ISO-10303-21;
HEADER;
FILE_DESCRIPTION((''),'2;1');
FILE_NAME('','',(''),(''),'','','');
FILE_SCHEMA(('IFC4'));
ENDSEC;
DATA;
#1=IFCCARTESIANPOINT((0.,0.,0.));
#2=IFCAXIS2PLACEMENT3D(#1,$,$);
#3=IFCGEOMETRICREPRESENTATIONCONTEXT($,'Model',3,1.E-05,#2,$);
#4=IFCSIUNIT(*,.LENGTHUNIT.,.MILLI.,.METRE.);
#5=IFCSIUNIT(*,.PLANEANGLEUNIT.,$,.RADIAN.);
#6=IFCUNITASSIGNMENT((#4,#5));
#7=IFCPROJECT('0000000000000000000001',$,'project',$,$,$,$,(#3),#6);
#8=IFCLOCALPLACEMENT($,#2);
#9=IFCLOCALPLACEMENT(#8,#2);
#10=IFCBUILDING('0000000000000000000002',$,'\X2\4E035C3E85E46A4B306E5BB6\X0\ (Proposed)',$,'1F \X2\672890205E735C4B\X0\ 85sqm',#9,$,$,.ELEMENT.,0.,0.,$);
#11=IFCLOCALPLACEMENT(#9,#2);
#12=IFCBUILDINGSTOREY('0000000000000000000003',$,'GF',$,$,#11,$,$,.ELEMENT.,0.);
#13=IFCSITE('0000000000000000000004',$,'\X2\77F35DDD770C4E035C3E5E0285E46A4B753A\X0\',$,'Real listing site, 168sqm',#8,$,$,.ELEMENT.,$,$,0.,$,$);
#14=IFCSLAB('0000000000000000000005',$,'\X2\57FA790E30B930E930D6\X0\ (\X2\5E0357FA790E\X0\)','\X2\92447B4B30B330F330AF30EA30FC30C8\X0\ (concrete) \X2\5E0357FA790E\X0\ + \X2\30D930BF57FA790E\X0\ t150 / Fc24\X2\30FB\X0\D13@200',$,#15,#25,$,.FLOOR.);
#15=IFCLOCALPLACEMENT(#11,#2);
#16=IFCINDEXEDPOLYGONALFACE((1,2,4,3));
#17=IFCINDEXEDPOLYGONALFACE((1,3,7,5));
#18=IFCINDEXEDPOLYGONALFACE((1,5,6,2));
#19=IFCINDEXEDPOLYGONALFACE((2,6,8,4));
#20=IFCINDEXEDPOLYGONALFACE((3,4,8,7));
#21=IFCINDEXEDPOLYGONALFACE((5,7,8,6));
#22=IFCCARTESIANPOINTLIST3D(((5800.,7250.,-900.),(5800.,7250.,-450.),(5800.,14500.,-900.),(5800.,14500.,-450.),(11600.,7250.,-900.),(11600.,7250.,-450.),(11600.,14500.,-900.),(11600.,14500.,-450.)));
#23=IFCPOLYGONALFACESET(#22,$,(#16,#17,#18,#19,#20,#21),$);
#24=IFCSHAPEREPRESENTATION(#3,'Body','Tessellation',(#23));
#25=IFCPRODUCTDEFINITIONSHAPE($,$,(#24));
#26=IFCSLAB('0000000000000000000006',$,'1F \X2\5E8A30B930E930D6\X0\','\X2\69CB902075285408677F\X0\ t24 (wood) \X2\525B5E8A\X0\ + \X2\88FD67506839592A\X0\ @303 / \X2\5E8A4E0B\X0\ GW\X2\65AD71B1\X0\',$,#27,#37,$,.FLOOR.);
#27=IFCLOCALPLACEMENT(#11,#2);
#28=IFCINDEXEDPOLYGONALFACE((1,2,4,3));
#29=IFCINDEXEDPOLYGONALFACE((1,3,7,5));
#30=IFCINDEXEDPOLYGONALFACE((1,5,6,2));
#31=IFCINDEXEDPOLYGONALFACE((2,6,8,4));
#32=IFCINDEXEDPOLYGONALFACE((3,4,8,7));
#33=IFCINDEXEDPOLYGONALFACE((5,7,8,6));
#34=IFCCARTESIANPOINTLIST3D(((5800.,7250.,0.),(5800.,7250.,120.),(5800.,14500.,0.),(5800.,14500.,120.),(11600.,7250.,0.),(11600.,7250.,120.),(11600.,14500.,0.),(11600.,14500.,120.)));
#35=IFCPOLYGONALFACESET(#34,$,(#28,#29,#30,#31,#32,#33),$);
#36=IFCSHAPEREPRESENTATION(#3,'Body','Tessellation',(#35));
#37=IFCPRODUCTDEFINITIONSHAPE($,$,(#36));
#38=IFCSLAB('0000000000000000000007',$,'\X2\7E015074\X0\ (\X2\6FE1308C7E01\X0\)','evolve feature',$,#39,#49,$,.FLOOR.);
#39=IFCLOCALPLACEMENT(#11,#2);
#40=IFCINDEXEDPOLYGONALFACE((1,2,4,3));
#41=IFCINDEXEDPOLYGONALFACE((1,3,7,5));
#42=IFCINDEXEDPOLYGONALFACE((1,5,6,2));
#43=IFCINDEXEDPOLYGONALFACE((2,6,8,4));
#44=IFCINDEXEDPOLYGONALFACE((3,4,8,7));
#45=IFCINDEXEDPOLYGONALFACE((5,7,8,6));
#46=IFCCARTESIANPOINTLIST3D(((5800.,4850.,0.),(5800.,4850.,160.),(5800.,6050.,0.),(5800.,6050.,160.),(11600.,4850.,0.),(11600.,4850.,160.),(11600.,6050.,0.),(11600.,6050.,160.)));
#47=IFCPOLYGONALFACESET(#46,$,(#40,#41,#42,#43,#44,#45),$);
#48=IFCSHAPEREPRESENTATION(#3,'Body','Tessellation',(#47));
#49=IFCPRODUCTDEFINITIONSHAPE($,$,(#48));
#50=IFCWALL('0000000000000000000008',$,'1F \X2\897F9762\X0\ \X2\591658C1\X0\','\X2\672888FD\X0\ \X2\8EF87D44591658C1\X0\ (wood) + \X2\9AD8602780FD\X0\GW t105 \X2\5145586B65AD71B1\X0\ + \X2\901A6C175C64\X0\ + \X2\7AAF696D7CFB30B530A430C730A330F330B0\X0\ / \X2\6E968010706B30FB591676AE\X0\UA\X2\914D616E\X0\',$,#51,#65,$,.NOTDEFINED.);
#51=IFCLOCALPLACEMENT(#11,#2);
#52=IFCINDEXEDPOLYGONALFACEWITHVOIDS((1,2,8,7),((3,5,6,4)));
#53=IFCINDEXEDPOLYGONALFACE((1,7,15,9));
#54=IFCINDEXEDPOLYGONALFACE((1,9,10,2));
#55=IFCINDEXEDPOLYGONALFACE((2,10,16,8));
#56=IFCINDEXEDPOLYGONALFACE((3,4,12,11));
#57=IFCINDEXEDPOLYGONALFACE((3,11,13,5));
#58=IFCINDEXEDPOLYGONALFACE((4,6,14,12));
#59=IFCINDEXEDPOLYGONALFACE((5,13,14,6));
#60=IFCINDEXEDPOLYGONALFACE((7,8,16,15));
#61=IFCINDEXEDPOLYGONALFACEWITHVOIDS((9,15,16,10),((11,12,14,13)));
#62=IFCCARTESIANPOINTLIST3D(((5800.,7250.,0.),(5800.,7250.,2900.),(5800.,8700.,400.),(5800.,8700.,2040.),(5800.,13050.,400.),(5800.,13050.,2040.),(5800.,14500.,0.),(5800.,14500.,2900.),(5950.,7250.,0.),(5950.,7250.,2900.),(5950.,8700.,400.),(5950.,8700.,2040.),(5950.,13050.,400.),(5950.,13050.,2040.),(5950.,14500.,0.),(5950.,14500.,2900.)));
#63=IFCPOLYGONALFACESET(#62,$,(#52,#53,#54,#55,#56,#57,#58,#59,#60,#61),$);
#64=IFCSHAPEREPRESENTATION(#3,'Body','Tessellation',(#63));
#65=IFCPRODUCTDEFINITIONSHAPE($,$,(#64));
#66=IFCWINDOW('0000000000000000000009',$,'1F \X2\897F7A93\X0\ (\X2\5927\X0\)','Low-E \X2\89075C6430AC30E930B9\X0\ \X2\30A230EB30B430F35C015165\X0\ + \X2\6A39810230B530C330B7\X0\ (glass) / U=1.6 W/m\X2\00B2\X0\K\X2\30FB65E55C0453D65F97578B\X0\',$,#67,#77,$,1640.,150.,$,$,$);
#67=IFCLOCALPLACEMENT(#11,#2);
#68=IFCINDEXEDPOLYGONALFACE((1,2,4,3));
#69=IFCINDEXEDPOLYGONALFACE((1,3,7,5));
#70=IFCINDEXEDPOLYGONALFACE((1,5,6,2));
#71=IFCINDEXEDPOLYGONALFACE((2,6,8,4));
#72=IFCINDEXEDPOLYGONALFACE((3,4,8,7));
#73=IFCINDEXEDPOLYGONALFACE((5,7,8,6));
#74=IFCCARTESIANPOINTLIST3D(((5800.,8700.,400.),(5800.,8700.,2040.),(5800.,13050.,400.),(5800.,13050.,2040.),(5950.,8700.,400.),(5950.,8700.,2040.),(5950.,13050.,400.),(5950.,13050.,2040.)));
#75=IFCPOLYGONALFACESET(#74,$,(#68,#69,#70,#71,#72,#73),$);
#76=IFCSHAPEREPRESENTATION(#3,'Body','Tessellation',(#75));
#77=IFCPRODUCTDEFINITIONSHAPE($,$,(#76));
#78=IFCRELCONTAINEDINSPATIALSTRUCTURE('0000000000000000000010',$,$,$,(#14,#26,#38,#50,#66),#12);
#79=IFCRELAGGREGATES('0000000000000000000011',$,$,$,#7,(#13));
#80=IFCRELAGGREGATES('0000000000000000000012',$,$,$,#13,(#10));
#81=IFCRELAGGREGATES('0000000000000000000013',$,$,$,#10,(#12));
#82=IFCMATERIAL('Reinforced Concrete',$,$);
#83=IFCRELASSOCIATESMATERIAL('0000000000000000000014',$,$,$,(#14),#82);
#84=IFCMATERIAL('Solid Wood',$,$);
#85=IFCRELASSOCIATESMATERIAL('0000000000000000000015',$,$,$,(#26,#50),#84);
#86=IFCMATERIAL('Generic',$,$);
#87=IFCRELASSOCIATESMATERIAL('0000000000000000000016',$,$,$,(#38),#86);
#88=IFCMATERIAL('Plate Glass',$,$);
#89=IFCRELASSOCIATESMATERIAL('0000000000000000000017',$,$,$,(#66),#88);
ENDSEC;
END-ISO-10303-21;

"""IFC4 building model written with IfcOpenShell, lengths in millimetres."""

from ifc_helpers import new_model, si_unit, frame, frame_2d, origin, place, context, project, spatial, rectangle, extrude, material, element, fill, save


model = new_model("IFC4")

# Units and contexts
model_context = context("Model", 3, precision=1e-05, world=origin())
ifc_project = project(units=[si_unit("LENGTHUNIT", "METRE", prefix="MILLI"), si_unit("PLANEANGLEUNIT", "RADIAN")], contexts=[model_context])

# Site, building, storey
site_placement = place(None, origin())
site = spatial("IfcSite", under=ifc_project, at=site_placement, Name="石川県七尾市藤橋町", ObjectType="Real listing site, 168sqm", CompositionType="ELEMENT", RefElevation=0.0)
building_placement = place(site_placement, origin())
building = spatial("IfcBuilding", under=site, at=building_placement, Name="七尾藤橋の家 (Proposed)", ObjectType="1F 木造平屋 85sqm", CompositionType="ELEMENT", ElevationOfRefHeight=0.0, ElevationOfTerrain=0.0)
storey_placement = place(building_placement, origin())
storey = spatial("IfcBuildingStorey", under=building, at=storey_placement, Name="GF", CompositionType="ELEMENT", Elevation=0.0)

# Slabs
ifc_material_1 = material(Name="Reinforced Concrete")
slab_1_placement = place(storey_placement, frame((2900.0, 3625.0, -450.0)))
element("IfcSlab", 1, at=slab_1_placement, inside=storey, material=ifc_material_1, Name="基礎スラブ (布基礎)", Description="鉄筋コンクリート (concrete) 布基礎 + ベタ基礎 t150 / Fc24・D13@200", PredefinedType="FLOOR", context=model_context, shape_type="SweptSolid", body=[
    extrude(rectangle(XDim=5800.0, YDim=7250.0, at=frame_2d((2900.0, 3625.0))), frame((2900.0, 3625.0, -450.0)), (0.0, 0.0, 1.0), 450.0),
])
ifc_material_2 = material(Name="Solid Wood")
slab_2_placement = place(storey_placement, frame((2900.0, 3625.0, 0.0)))
element("IfcSlab", 2, at=slab_2_placement, inside=storey, material=ifc_material_2, Name="1F 床スラブ", Description="構造用合板 t24 (wood) 剛床 + 製材根太 @303 / 床下 GW断熱", PredefinedType="FLOOR", context=model_context, shape_type="SweptSolid", body=[
    extrude(rectangle(XDim=5800.0, YDim=7250.0, at=frame_2d((2900.0, 3625.0))), frame((2900.0, 3625.0, 0.0)), (0.0, 0.0, 1.0), 120.0),
])
ifc_material_3 = material(Name="Generic")
slab_3_placement = place(storey_placement, frame((2900.0, 2425.0, 0.0)))
element("IfcSlab", 3, at=slab_3_placement, inside=storey, material=ifc_material_3, Name="縁側 (濡れ縁)", Description="evolve feature", PredefinedType="FLOOR", context=model_context, shape_type="SweptSolid", body=[
    extrude(rectangle(XDim=5800.0, YDim=1200.0, at=frame_2d((2900.0, 600.0))), frame((2900.0, 2425.0, 0.0)), (0.0, 0.0, 1.0), 160.0),
])

# Shared definitions
ifc_material_4 = material(Name="Plate Glass")

# Wall, opening, window
wall_1_placement = place(storey_placement, frame((2900.0, 3625.0, 0.0)))
wall_1 = element("IfcWall", 4, at=wall_1_placement, inside=storey, material=ifc_material_2, Name="1F 西面 外壁", Description="木製 軸組外壁 (wood) + 高性能GW t105 充填断熱 + 通気層 + 窯業系サイディング / 準耐火・外皮UA配慮", PredefinedType="NOTDEFINED", context=model_context, shape_type="SweptSolid", body=[
    extrude(rectangle(XDim=150.0, YDim=7250.0, at=frame_2d((75.0, 3625.0))), frame((2900.0, 3625.0, 0.0)), (0.0, 0.0, 1.0), 2900.0),
])
opening_1_placement = place(storey_placement, frame((2900.0, 4350.0, 200.0)))
opening_1 = element("IfcOpeningElement", 5, at=opening_1_placement, cuts=wall_1, PredefinedType="NOTDEFINED", context=model_context, shape_type="SweptSolid", body=[
    extrude(rectangle(XDim=150.0, YDim=4350.0, at=frame_2d((75.0, 2175.0))), frame((2900.0, 4350.0, 200.0)), (0.0, 0.0, 1.0), 1640.0),
])
window_1_placement = place(storey_placement, frame((2900.0, 4350.0, 200.0)))
window_1 = element("IfcWindow", 6, at=window_1_placement, inside=storey, material=ifc_material_4, Name="1F 西窓 (大)", Description="Low-E 複層ガラス アルゴン封入 + 樹脂サッシ (glass) / U=1.6 W/m²K・日射取得型", OverallHeight=1640.0, OverallWidth=150.0, context=model_context, shape_type="SweptSolid", body=[
    extrude(rectangle(XDim=150.0, YDim=4350.0, at=frame_2d((75.0, 2175.0))), frame((2900.0, 4350.0, 200.0)), (0.0, 0.0, 1.0), 1640.0),
])
fill(opening_1, window_1)

save(model, "model.ifc")
